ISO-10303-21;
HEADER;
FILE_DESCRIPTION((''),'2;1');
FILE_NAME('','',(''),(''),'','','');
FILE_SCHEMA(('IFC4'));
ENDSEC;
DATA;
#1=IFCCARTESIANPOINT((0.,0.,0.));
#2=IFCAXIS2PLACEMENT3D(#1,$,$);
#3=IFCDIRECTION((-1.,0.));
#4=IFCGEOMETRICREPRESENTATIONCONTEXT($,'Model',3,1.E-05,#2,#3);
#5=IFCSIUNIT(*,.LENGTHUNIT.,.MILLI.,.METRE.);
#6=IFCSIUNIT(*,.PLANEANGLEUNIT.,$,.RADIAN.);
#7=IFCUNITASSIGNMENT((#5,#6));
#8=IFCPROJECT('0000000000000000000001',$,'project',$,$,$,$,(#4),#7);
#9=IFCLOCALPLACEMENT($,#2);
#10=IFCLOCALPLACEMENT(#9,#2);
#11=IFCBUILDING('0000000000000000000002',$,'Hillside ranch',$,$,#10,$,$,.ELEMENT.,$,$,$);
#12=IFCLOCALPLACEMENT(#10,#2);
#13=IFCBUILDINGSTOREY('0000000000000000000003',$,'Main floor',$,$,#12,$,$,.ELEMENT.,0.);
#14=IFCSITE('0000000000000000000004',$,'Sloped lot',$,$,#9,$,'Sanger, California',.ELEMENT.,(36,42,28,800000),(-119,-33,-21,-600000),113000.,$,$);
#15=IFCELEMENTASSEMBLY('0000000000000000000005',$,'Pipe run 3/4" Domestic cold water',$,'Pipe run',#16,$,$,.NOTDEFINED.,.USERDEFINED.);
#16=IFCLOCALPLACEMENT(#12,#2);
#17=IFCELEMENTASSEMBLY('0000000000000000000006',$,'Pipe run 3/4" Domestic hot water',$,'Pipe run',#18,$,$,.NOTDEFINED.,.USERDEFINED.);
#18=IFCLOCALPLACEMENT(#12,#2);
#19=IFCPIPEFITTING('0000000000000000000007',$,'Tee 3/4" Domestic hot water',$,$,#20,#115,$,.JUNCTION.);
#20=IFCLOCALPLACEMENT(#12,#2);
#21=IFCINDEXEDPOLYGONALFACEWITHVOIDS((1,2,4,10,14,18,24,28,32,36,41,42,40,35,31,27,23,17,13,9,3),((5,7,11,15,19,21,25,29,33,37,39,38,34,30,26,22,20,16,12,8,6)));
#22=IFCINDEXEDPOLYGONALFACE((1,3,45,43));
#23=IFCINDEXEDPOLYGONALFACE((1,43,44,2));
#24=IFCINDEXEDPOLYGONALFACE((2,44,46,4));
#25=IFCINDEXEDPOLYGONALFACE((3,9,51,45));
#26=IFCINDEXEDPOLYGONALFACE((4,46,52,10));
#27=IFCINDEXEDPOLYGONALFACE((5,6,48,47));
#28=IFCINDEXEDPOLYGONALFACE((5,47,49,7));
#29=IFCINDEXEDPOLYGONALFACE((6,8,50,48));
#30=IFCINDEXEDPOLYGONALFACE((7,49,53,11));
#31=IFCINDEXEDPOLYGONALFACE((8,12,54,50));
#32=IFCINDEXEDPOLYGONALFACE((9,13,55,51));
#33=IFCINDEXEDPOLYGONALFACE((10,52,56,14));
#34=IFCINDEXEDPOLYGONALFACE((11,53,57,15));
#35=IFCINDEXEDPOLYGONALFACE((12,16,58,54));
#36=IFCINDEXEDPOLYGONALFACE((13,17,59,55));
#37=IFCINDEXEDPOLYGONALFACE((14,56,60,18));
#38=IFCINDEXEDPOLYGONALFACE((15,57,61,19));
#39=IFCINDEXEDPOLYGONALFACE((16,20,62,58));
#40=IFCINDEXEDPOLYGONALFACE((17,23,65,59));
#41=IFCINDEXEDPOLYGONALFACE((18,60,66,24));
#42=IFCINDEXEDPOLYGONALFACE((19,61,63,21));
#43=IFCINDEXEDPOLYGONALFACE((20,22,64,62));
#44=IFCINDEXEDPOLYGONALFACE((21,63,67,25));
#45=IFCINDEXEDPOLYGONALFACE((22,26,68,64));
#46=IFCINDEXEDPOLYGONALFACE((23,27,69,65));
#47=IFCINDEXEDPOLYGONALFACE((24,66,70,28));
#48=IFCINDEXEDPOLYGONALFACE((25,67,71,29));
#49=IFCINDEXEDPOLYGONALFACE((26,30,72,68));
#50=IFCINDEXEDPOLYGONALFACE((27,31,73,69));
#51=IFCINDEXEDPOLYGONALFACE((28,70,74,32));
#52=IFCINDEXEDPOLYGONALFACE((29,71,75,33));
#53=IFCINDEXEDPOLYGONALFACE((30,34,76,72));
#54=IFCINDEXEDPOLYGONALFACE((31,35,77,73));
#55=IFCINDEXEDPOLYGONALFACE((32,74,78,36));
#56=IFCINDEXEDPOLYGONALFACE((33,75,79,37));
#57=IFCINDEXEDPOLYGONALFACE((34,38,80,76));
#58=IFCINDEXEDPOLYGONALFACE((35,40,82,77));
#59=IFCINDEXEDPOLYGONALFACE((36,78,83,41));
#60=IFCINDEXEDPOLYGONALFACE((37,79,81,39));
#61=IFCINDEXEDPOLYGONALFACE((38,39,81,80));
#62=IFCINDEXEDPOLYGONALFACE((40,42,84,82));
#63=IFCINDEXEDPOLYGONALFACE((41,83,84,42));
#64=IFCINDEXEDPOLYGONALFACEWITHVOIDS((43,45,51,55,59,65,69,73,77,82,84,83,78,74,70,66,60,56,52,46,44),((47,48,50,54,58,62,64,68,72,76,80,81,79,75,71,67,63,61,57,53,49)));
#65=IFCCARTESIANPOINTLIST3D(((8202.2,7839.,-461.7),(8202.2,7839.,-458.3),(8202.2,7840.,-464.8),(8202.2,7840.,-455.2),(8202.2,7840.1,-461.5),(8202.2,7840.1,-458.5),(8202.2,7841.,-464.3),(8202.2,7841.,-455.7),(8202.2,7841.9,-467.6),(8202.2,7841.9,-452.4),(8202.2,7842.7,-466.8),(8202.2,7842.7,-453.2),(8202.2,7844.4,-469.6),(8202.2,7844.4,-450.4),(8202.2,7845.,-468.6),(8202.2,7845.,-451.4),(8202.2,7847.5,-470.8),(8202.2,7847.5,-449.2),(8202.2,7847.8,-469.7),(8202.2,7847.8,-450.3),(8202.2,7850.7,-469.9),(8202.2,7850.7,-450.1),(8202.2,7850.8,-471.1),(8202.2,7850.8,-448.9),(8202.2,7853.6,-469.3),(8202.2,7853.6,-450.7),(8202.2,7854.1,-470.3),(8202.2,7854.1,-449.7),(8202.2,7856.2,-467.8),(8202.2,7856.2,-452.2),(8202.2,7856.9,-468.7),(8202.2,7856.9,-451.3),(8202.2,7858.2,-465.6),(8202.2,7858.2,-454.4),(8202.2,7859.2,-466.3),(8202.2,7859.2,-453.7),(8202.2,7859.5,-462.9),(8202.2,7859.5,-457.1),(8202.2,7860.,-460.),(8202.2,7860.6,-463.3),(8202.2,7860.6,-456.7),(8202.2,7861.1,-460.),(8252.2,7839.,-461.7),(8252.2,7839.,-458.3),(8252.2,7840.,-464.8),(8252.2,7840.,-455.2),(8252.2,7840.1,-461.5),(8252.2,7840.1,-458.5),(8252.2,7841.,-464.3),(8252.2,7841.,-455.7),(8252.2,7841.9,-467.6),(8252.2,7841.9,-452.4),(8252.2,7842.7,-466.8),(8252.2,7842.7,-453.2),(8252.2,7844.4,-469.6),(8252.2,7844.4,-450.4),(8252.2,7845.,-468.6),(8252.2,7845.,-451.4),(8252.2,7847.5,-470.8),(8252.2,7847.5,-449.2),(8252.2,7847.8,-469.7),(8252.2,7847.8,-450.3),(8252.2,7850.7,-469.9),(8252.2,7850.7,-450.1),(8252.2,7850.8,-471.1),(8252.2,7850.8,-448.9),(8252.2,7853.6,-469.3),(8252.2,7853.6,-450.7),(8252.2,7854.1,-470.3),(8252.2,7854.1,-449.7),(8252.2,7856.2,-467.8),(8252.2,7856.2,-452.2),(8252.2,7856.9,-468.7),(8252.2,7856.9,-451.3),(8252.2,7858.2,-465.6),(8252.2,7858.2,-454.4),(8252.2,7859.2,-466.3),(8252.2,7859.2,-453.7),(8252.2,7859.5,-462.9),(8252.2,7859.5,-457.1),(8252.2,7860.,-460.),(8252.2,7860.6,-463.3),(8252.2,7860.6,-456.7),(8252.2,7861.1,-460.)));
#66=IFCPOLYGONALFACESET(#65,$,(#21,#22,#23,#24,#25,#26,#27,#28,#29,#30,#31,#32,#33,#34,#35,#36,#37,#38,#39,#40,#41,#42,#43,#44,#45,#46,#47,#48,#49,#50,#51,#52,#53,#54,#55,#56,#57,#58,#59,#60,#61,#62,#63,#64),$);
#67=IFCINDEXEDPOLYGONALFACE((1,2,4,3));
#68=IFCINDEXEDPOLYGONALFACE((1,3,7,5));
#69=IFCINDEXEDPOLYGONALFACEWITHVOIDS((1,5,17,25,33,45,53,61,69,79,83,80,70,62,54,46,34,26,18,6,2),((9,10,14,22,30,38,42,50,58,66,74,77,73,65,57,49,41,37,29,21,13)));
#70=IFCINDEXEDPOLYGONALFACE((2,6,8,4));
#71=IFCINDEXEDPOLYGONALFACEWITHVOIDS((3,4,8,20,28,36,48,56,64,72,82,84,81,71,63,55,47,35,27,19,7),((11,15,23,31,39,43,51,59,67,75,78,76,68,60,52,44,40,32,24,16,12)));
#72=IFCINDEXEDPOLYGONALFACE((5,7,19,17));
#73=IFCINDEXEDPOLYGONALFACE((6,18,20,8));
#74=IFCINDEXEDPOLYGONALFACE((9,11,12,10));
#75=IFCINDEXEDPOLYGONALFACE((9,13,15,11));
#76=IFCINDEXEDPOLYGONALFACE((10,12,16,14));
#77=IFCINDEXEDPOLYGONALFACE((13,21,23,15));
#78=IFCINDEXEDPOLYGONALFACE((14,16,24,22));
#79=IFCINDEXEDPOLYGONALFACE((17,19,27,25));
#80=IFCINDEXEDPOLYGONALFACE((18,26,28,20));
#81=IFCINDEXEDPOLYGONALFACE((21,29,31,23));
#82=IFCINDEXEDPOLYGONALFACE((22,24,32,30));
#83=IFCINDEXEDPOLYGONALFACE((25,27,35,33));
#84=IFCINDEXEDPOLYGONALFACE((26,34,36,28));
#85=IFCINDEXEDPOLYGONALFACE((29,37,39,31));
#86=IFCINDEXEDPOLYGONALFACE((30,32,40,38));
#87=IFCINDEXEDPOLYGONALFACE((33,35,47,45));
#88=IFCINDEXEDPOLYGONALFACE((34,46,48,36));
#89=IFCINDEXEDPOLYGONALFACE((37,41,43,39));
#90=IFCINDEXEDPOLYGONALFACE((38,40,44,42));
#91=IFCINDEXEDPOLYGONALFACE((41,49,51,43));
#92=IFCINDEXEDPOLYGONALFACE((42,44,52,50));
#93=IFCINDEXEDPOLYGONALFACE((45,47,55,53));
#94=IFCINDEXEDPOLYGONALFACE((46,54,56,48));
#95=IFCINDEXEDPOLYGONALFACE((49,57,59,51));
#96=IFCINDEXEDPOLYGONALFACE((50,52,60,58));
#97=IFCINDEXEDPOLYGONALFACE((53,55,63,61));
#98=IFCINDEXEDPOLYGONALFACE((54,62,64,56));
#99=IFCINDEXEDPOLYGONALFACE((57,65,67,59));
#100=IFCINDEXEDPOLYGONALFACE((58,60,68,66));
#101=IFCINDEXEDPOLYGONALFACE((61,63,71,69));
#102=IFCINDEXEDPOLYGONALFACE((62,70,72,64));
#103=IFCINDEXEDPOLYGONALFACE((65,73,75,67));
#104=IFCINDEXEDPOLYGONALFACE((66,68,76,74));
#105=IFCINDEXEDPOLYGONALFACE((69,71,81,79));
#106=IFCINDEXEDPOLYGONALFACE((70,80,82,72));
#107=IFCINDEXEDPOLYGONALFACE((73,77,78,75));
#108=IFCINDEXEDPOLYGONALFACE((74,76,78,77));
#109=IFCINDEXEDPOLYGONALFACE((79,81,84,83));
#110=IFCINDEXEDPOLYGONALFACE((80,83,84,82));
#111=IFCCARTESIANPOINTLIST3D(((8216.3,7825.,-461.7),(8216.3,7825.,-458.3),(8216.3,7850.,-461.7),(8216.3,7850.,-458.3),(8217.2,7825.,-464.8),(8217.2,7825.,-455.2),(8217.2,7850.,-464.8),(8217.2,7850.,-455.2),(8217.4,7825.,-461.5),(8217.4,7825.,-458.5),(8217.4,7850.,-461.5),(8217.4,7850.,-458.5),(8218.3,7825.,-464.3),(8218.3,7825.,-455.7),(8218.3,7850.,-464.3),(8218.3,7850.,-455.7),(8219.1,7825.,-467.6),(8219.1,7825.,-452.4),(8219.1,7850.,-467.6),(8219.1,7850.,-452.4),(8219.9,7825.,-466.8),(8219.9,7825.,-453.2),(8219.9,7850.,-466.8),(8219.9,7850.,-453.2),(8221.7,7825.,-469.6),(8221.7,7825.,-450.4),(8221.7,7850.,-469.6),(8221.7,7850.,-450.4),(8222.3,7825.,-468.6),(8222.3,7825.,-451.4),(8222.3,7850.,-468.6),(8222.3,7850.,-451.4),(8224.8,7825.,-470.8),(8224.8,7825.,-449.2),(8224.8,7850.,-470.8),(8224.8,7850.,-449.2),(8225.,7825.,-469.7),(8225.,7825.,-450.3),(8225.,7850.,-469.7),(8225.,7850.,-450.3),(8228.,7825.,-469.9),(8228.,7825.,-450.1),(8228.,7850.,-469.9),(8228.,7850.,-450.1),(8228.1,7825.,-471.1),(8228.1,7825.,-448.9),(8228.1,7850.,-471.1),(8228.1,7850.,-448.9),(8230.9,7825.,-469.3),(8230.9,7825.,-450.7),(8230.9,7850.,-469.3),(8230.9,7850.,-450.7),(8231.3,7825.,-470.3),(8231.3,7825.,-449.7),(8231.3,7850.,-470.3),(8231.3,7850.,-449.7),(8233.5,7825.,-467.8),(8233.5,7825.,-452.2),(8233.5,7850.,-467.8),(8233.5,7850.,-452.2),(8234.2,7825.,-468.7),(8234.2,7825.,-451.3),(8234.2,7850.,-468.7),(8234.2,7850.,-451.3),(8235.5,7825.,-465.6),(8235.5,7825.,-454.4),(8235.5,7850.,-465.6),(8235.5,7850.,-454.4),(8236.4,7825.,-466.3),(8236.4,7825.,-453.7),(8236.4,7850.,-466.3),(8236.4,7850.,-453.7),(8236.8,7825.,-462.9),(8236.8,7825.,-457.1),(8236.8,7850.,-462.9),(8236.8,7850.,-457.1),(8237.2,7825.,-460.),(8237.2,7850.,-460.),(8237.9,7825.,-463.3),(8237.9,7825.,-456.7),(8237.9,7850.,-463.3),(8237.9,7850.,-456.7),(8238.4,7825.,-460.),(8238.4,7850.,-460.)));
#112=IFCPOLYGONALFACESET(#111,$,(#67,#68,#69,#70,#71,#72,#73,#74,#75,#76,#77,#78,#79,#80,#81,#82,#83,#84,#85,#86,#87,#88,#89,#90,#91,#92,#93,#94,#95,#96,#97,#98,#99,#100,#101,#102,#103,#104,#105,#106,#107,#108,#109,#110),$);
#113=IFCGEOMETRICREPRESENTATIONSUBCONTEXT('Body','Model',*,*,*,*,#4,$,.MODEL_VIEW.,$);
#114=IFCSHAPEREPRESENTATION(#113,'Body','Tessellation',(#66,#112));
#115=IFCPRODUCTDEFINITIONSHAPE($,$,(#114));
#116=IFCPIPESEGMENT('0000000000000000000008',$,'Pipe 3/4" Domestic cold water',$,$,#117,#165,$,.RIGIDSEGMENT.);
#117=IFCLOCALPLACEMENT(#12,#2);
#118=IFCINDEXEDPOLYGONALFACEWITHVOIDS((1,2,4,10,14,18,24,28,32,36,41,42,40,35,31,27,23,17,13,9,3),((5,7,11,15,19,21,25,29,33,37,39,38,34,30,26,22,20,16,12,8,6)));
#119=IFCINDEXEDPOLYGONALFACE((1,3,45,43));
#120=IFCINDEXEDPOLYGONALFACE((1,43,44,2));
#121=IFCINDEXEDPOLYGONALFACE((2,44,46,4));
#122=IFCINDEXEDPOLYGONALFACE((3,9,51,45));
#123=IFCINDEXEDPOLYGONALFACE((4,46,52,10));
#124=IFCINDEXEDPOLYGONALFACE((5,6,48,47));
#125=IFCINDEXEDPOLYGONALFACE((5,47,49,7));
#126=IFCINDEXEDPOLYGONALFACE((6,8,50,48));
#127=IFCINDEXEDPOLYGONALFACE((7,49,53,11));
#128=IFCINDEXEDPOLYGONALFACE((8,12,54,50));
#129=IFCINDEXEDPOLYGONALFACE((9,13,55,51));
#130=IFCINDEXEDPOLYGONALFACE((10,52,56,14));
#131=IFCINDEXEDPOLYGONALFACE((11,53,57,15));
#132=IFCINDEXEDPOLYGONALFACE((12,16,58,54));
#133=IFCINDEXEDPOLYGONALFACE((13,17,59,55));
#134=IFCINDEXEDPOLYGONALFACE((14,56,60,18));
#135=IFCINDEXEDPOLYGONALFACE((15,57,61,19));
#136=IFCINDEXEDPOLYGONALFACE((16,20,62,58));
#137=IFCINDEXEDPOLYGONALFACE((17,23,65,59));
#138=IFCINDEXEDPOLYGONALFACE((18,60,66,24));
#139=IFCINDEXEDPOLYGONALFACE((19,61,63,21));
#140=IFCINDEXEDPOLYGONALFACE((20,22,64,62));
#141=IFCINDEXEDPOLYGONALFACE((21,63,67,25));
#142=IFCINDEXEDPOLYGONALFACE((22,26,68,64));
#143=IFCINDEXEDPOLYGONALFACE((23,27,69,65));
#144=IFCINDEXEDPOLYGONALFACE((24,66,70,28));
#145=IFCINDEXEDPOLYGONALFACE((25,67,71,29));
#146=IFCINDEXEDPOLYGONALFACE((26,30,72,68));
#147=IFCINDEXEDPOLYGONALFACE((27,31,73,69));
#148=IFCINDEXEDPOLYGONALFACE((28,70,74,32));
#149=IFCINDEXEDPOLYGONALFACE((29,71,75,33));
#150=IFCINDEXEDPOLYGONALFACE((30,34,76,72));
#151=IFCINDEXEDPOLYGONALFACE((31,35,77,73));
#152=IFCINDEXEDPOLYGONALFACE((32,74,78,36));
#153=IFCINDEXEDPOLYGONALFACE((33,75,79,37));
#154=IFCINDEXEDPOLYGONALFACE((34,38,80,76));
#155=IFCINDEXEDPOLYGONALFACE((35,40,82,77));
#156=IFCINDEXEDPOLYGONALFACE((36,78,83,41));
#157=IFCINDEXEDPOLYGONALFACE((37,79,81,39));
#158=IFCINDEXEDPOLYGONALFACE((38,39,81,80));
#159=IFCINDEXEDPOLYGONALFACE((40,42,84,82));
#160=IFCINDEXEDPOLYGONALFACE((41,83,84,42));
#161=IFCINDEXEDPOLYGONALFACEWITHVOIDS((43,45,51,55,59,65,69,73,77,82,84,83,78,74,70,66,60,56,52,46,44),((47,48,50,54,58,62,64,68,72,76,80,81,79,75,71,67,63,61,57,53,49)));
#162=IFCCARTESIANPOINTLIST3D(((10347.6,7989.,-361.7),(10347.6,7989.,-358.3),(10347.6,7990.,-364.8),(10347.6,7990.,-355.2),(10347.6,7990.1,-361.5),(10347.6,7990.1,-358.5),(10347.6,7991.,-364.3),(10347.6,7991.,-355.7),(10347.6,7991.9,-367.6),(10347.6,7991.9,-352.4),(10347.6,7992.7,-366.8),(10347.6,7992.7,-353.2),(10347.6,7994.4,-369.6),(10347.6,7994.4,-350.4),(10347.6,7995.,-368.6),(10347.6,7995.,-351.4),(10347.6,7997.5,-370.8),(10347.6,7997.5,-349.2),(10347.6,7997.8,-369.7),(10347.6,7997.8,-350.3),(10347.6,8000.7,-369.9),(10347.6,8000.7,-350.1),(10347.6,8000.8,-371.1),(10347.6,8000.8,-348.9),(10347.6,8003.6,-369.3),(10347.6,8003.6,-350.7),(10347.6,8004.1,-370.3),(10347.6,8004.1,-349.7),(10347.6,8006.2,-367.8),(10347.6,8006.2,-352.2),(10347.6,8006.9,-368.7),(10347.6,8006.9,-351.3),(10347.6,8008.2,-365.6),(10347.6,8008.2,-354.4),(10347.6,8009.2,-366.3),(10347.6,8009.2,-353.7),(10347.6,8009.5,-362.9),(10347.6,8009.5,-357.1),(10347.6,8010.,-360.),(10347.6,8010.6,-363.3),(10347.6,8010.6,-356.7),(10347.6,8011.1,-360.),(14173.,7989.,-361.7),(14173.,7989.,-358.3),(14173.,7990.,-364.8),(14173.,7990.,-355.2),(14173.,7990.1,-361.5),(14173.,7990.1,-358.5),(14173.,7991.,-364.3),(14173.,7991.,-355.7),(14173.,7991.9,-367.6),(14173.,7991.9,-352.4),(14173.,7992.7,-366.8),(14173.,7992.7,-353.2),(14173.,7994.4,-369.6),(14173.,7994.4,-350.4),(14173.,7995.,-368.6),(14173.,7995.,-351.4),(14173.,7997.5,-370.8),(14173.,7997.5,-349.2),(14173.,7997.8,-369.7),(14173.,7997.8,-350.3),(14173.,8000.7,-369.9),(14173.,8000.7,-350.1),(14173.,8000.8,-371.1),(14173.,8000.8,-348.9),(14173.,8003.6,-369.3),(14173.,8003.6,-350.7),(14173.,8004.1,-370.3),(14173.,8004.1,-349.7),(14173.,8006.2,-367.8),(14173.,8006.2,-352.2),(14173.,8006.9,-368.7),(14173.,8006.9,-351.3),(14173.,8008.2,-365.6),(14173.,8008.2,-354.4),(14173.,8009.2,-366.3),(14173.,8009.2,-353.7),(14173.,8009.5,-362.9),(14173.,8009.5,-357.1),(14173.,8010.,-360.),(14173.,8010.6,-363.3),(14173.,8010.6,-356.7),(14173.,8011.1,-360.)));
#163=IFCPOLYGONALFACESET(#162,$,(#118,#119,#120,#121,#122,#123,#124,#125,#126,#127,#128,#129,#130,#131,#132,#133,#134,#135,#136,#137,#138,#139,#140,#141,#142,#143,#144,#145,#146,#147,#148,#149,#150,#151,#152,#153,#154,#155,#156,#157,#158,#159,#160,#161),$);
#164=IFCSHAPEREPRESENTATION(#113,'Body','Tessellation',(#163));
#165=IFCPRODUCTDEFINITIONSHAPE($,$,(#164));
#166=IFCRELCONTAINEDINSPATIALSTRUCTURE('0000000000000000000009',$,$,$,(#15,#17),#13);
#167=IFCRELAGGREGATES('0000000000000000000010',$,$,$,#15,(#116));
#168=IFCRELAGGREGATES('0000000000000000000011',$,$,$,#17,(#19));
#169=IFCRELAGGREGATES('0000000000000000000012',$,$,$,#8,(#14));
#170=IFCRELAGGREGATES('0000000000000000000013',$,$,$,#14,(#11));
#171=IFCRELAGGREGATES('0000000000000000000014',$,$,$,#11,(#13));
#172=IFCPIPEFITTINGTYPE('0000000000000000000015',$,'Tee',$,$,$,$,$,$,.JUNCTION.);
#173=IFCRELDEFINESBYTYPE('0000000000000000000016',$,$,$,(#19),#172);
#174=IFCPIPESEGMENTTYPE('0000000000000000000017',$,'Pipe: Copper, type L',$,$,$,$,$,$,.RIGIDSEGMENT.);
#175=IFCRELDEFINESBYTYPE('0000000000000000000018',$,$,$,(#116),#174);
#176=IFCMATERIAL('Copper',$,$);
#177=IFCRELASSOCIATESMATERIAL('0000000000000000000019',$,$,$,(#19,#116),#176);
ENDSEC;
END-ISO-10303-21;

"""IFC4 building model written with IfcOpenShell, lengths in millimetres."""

from ifc_helpers import new_model, si_unit, direction, frame, origin, origin_with_axes, origin_2d, place, context, subcontext, project, spatial, hollow_circle, extrude, material, type_object, element, aggregate, save


model = new_model("IFC4")

# Units and contexts
model_context = context("Model", 3, precision=1e-05, world=origin(), true_north=direction((-1.0, 0.0)))
body_context = subcontext(model_context, "Body", "Model", "MODEL_VIEW")
ifc_project = project(units=[si_unit("LENGTHUNIT", "METRE", prefix="MILLI"), si_unit("PLANEANGLEUNIT", "RADIAN")], contexts=[model_context])

# Site, building, storey
site_placement = place(None, origin())
site = spatial("IfcSite", under=ifc_project, at=site_placement, Name="Sloped lot", LongName="Sanger, California", CompositionType="ELEMENT", RefLatitude=(36, 42, 28, 800000), RefLongitude=(-119, -33, -21, -600000), RefElevation=113000.0)
building_placement = place(site_placement, origin())
building = spatial("IfcBuilding", under=site, at=building_placement, Name="Hillside ranch", CompositionType="ELEMENT")
storey_placement = place(building_placement, origin())
storey = spatial("IfcBuildingStorey", under=building, at=storey_placement, Name="Main floor", CompositionType="ELEMENT", Elevation=0.0)

# Element assemblies, pipe fitting
assembly_1_placement = place(storey_placement, origin_with_axes())
assembly_1 = element("IfcElementAssembly", 1, at=assembly_1_placement, inside=storey, Name="Pipe run 3/4\" Domestic cold water", ObjectType="Pipe run", AssemblyPlace="NOTDEFINED", PredefinedType="USERDEFINED")
ifc_material = material(Name="Copper")
pipe_fitting_type_1 = type_object("IfcPipeFittingType", Name="Tee", PredefinedType="JUNCTION")
assembly_2_placement = place(storey_placement, origin_with_axes())
assembly_2 = element("IfcElementAssembly", 2, at=assembly_2_placement, inside=storey, Name="Pipe run 3/4\" Domestic hot water", ObjectType="Pipe run", AssemblyPlace="NOTDEFINED", PredefinedType="USERDEFINED")
pipe_fitting_1_placement = place(storey_placement, origin_with_axes())
pipe_fitting_1 = element("IfcPipeFitting", 3, at=pipe_fitting_1_placement, type_object=pipe_fitting_type_1, material=ifc_material, Name="Tee 3/4\" Domestic hot water", PredefinedType="JUNCTION", context=body_context, shape_type="SweptSolid", body=[
    extrude(hollow_circle(Radius=11.1, WallThickness=1.1, at=origin_2d()), frame((8202.2, 7850.0, -460.0), z_axis=(1.0, 0.0, 0.0), x_axis=(0.0, 1.0, 0.0)), (0.0, 0.0, 1.0), 50.0),
    extrude(hollow_circle(Radius=11.1, WallThickness=1.1, at=origin_2d()), frame((8227.2, 7850.0, -460.0), z_axis=(0.0, -1.0, 0.0), x_axis=(1.0, 0.0, 0.0)), (0.0, 0.0, 1.0), 25.0),
])

# Pipe segment
pipe_segment_type = type_object("IfcPipeSegmentType", Name="Pipe: Copper, type L", PredefinedType="RIGIDSEGMENT")
pipe_segment_1_placement = place(storey_placement, origin_with_axes())
pipe_segment_1 = element("IfcPipeSegment", 4, at=pipe_segment_1_placement, type_object=pipe_segment_type, material=ifc_material, Name="Pipe 3/4\" Domestic cold water", PredefinedType="RIGIDSEGMENT", context=body_context, shape_type="SweptSolid", body=[
    extrude(hollow_circle(Radius=11.1, WallThickness=1.1, at=origin_2d()), frame((10347.6, 8000.0, -360.0), z_axis=(1.0, 0.0, 0.0), x_axis=(0.0, 1.0, 0.0)), (0.0, 0.0, 1.0), 3825.3),
])
aggregate(assembly_1, [pipe_segment_1])
aggregate(assembly_2, [pipe_fitting_1])

save(model, "model.ifc")
